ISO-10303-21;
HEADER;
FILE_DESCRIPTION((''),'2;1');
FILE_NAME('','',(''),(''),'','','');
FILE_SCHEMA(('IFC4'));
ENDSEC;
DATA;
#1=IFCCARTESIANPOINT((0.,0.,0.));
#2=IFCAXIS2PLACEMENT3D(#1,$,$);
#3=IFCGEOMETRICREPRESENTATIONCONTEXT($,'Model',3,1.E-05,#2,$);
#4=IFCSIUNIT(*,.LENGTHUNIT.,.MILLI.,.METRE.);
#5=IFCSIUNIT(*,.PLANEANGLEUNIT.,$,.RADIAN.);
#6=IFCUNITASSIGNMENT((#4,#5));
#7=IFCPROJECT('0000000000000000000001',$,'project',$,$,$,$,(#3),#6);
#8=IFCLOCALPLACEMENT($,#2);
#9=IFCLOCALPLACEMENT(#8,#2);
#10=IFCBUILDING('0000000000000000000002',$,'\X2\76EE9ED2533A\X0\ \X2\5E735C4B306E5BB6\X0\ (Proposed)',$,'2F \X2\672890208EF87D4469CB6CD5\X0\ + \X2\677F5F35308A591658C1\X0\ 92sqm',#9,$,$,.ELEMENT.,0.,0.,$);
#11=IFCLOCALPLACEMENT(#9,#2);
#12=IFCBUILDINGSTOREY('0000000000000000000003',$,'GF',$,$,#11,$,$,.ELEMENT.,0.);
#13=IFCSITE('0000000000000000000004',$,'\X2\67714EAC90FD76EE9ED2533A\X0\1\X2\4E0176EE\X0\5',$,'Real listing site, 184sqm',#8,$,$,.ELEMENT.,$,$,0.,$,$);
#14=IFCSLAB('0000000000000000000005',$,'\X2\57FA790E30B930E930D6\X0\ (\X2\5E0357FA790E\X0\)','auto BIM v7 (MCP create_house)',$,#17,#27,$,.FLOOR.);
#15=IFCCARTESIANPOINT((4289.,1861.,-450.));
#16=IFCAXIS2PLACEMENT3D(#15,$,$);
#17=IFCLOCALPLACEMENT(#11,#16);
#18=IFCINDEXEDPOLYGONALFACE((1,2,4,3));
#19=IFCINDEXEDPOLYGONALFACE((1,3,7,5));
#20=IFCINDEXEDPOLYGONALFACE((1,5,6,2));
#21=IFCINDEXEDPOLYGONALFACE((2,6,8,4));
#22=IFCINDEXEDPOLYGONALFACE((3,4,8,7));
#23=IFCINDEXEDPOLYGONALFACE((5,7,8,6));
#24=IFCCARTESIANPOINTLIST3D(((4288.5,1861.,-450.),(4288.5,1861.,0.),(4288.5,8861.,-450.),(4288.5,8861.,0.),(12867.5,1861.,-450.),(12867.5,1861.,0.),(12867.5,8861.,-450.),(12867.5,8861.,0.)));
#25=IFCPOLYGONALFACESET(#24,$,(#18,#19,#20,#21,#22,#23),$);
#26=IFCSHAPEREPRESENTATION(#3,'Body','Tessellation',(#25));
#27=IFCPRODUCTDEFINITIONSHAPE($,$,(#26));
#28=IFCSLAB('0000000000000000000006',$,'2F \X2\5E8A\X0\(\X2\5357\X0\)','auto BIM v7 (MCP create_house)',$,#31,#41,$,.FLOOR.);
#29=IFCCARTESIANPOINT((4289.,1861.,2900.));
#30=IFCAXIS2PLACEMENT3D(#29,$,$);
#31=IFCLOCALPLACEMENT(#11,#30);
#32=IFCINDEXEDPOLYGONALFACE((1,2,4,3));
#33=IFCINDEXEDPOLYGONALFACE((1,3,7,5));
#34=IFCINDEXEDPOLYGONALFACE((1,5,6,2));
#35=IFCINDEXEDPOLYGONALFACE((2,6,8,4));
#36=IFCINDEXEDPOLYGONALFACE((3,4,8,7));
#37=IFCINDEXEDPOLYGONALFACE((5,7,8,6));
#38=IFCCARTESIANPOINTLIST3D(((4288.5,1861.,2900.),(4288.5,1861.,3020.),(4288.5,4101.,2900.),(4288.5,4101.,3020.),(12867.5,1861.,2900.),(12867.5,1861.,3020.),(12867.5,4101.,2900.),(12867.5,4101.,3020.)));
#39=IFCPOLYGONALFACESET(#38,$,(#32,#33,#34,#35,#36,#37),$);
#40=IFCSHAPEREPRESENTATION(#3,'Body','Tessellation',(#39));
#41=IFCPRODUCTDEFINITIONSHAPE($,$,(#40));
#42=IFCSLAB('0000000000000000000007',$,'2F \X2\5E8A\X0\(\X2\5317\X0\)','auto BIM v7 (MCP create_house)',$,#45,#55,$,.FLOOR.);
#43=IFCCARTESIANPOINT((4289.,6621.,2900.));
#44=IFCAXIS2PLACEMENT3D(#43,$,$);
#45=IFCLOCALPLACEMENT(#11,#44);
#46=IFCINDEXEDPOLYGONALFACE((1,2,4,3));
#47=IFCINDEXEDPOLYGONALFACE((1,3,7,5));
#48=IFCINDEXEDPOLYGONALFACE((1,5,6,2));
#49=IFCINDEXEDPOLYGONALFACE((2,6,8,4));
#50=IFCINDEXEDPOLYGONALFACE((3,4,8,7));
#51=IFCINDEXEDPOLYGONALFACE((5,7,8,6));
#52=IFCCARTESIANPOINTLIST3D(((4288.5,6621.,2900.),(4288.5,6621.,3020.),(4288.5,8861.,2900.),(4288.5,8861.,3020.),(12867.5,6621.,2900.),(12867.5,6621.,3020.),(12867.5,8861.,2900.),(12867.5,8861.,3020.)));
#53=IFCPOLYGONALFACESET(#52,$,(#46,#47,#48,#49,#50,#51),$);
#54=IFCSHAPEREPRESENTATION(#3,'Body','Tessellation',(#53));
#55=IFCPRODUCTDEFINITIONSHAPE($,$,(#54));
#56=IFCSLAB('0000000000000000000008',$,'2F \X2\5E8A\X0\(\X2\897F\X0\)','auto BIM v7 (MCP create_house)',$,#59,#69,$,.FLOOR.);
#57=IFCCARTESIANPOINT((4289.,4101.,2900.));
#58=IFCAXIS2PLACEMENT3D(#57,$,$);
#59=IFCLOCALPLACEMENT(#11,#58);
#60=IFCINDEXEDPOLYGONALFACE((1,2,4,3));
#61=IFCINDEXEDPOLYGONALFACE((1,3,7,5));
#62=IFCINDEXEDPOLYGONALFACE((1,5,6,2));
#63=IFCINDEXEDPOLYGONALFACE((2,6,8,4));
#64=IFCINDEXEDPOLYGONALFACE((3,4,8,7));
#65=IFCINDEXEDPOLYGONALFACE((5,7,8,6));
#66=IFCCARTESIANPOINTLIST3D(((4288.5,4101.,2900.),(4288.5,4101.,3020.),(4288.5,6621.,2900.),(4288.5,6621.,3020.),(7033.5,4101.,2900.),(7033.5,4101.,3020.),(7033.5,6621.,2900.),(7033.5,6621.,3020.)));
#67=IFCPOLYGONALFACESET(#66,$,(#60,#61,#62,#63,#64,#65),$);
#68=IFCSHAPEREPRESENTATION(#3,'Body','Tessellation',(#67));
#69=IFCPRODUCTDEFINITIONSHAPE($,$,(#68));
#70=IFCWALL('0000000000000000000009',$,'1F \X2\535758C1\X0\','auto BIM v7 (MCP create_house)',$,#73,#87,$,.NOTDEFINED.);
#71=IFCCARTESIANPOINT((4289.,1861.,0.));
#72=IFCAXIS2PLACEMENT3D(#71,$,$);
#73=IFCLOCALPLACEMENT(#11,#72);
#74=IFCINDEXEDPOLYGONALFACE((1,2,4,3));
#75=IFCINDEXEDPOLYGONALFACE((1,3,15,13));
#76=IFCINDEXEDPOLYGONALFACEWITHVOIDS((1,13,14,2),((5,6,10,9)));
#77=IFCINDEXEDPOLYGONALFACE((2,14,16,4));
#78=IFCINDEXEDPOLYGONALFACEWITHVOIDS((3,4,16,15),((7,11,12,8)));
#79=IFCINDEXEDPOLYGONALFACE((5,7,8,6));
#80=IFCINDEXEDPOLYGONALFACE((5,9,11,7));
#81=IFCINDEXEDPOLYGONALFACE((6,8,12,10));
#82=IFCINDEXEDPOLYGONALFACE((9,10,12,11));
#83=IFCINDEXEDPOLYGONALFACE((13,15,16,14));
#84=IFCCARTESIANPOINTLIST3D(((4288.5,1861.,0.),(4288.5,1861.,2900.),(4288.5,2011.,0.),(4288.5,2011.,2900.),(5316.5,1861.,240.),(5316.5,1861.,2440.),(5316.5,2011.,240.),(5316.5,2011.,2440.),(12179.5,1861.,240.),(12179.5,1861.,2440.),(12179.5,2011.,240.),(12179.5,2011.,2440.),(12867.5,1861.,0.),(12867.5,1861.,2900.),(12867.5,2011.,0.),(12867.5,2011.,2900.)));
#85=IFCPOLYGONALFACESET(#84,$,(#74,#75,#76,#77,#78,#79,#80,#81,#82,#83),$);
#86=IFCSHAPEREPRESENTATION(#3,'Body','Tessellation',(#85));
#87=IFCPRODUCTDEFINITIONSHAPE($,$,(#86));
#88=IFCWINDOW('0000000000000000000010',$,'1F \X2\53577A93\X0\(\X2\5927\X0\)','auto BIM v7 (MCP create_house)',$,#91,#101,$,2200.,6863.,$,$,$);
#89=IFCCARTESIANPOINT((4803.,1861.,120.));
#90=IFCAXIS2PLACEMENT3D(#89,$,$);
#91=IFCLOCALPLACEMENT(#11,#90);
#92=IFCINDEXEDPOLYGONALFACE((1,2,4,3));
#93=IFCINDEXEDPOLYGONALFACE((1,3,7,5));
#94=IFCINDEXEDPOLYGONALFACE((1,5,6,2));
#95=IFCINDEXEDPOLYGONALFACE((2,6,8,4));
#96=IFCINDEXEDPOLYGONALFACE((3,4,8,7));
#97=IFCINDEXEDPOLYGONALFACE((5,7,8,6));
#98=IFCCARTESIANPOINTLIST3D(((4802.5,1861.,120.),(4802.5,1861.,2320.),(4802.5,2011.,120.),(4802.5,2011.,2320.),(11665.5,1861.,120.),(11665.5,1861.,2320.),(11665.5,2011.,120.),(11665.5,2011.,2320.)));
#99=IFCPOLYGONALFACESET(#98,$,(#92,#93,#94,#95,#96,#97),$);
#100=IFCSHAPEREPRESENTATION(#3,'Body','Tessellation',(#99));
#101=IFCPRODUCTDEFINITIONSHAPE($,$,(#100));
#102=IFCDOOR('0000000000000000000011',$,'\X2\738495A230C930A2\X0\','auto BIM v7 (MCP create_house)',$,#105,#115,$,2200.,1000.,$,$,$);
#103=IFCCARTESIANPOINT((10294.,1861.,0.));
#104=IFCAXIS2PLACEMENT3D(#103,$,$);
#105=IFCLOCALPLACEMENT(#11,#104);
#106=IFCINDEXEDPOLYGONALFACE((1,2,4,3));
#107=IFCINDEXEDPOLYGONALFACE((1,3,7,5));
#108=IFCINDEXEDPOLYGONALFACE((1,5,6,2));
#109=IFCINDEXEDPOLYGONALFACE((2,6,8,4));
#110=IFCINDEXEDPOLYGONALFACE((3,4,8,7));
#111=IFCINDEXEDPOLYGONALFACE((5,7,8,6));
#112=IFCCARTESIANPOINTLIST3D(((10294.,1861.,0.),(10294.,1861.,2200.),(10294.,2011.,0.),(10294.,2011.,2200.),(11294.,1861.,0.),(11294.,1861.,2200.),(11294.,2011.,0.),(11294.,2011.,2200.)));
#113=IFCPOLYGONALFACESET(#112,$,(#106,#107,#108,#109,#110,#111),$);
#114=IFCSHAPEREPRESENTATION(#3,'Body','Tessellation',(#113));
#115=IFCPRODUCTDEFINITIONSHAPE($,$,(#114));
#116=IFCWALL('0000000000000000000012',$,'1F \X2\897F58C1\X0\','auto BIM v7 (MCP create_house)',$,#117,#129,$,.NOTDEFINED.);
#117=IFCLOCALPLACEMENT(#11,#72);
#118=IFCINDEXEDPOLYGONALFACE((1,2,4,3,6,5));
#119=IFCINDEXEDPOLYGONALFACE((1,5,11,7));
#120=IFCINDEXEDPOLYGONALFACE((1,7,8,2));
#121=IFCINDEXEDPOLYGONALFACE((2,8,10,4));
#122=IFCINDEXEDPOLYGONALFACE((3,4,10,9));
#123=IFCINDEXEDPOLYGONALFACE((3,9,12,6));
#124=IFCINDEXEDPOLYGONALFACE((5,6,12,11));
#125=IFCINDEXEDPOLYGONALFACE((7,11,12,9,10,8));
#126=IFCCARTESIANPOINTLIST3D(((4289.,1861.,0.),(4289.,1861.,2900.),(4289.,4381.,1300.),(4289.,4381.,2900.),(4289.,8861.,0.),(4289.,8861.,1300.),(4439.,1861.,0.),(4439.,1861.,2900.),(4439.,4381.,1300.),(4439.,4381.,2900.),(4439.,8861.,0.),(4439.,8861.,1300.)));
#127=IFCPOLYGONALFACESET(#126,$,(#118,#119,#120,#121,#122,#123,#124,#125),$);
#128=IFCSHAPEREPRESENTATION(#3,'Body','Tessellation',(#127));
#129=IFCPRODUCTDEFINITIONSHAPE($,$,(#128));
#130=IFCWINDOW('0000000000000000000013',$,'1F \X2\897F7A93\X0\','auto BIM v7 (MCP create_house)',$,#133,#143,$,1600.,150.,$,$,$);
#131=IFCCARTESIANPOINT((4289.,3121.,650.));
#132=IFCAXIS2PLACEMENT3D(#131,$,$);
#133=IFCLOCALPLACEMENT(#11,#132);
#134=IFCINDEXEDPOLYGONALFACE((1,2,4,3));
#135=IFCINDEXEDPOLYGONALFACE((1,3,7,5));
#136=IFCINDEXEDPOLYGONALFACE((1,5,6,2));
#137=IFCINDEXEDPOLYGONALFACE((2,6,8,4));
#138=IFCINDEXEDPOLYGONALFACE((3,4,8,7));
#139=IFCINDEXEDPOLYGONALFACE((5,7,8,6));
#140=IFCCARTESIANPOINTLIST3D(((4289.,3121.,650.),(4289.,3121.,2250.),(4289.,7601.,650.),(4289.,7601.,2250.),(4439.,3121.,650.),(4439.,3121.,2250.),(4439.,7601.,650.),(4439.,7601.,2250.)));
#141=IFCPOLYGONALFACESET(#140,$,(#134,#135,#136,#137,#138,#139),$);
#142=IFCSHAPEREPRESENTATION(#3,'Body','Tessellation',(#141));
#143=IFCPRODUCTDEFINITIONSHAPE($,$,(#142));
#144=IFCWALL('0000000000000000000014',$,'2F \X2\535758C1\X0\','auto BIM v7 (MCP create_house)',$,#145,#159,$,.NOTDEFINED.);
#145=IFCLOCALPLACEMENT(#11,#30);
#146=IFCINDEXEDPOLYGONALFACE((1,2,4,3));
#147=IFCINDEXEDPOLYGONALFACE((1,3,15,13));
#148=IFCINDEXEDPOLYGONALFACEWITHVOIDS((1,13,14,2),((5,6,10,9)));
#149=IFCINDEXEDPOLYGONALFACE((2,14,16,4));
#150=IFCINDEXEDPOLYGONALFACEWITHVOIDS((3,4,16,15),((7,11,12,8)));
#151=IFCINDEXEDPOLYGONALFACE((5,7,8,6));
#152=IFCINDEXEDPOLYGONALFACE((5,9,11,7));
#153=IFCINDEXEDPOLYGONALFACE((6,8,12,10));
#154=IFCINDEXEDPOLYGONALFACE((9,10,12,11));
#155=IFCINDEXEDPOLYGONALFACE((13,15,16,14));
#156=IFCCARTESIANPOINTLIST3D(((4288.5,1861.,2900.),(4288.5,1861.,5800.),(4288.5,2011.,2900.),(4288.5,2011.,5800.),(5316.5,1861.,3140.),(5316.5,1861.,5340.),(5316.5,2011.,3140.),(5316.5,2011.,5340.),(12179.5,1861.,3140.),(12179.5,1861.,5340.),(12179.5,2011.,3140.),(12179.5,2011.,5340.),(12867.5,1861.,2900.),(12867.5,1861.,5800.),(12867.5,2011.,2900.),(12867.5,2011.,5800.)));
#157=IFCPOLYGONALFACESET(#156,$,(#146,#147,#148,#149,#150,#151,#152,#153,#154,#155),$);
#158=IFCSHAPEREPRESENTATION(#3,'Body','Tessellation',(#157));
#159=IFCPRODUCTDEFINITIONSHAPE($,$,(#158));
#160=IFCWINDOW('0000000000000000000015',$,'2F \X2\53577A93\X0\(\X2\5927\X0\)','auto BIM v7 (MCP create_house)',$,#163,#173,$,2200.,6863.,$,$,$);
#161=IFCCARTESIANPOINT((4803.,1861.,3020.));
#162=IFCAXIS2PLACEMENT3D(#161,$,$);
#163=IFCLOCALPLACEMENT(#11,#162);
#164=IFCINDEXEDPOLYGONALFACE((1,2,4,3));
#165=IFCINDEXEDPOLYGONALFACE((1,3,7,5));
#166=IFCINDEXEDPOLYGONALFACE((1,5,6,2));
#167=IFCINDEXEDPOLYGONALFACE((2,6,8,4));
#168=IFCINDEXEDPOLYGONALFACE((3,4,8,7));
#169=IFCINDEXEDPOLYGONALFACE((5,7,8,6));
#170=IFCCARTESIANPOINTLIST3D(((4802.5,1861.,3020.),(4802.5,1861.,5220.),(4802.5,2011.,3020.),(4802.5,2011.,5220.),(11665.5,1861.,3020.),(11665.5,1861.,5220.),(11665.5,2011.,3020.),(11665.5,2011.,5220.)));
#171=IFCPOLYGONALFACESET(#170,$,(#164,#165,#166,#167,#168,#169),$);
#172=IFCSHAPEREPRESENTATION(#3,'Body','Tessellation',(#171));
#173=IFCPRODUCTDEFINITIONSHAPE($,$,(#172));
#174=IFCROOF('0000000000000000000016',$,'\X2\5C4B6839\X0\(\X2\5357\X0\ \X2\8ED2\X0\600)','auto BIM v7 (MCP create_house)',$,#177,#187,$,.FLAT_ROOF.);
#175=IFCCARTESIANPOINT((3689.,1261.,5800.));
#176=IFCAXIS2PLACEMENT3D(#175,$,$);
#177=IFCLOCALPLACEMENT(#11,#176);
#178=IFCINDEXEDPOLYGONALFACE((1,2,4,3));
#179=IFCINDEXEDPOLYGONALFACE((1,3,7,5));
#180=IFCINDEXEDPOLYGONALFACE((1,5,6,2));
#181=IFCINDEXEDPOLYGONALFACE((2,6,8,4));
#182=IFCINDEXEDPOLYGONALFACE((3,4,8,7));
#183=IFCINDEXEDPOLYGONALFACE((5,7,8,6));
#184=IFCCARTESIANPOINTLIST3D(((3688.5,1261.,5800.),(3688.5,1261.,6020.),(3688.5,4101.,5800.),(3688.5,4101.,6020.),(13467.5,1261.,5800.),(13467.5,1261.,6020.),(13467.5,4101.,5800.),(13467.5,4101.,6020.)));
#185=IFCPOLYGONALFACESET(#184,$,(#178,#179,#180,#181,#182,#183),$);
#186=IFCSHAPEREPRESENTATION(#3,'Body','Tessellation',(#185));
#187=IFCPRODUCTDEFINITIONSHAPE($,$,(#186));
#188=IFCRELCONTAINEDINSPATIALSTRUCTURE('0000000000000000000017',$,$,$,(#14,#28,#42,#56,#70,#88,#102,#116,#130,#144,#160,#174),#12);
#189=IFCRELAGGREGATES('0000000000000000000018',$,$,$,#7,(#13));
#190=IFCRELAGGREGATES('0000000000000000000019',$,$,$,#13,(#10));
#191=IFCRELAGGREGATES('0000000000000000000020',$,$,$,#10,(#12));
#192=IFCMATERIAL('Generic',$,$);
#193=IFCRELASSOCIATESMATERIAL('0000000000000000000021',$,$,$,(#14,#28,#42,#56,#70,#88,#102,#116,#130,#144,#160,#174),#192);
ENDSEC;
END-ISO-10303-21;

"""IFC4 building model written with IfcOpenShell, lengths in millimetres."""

from ifc_helpers import new_model, si_unit, frame, frame_2d, origin, place, context, project, spatial, rectangle, extrude, material, element, fill, save


model = new_model("IFC4")

# Units and contexts
model_context = context("Model", 3, precision=1e-05, world=origin())
ifc_project = project(units=[si_unit("LENGTHUNIT", "METRE", prefix="MILLI"), si_unit("PLANEANGLEUNIT", "RADIAN")], contexts=[model_context])

# Site, building, storey
site_placement = place(None, origin())
site = spatial("IfcSite", under=ifc_project, at=site_placement, Name="東京都目黒区1丁目5", ObjectType="Real listing site, 184sqm", CompositionType="ELEMENT", RefElevation=0.0)
building_placement = place(site_placement, origin())
building = spatial("IfcBuilding", under=site, at=building_placement, Name="目黒区 平屋の家 (Proposed)", ObjectType="2F 木造軸組構法 + 板張り外壁 92sqm", CompositionType="ELEMENT", ElevationOfRefHeight=0.0, ElevationOfTerrain=0.0)
storey_placement = place(building_placement, origin())
storey = spatial("IfcBuildingStorey", under=building, at=storey_placement, Name="GF", CompositionType="ELEMENT", Elevation=0.0)

# Slabs
ifc_material = material(Name="Generic")
slab_1_placement = place(storey_placement, frame((4289.0, 1861.0, -450.0)))
element("IfcSlab", 1, at=slab_1_placement, inside=storey, material=ifc_material, Name="基礎スラブ (布基礎)", Description="auto BIM v7 (MCP create_house)", PredefinedType="FLOOR", context=model_context, shape_type="SweptSolid", body=[
    extrude(rectangle(XDim=8579.0, YDim=7000.0, at=frame_2d((4289.0, 3500.0))), frame((4289.0, 1861.0, -450.0)), (0.0, 0.0, 1.0), 450.0),
])
slab_2_placement = place(storey_placement, frame((4289.0, 1861.0, 2900.0)))
element("IfcSlab", 2, at=slab_2_placement, inside=storey, material=ifc_material, Name="2F 床(南)", Description="auto BIM v7 (MCP create_house)", PredefinedType="FLOOR", context=model_context, shape_type="SweptSolid", body=[
    extrude(rectangle(XDim=8579.0, YDim=2240.0, at=frame_2d((4289.0, 1120.0))), frame((4289.0, 1861.0, 2900.0)), (0.0, 0.0, 1.0), 120.0),
])
slab_3_placement = place(storey_placement, frame((4289.0, 6621.0, 2900.0)))
element("IfcSlab", 3, at=slab_3_placement, inside=storey, material=ifc_material, Name="2F 床(北)", Description="auto BIM v7 (MCP create_house)", PredefinedType="FLOOR", context=model_context, shape_type="SweptSolid", body=[
    extrude(rectangle(XDim=8579.0, YDim=2240.0, at=frame_2d((4289.0, 1120.0))), frame((4289.0, 6621.0, 2900.0)), (0.0, 0.0, 1.0), 120.0),
])
slab_4_placement = place(storey_placement, frame((4289.0, 4101.0, 2900.0)))
element("IfcSlab", 4, at=slab_4_placement, inside=storey, material=ifc_material, Name="2F 床(西)", Description="auto BIM v7 (MCP create_house)", PredefinedType="FLOOR", context=model_context, shape_type="SweptSolid", body=[
    extrude(rectangle(XDim=2745.0, YDim=2520.0, at=frame_2d((1372.0, 1260.0))), frame((4289.0, 4101.0, 2900.0)), (0.0, 0.0, 1.0), 120.0),
])

# Wall, openings, window, door
wall_1_placement = place(storey_placement, frame((4289.0, 1861.0, 0.0)))
wall_1 = element("IfcWall", 5, at=wall_1_placement, inside=storey, material=ifc_material, Name="1F 南壁", Description="auto BIM v7 (MCP create_house)", PredefinedType="NOTDEFINED", context=model_context, shape_type="SweptSolid", body=[
    extrude(rectangle(XDim=8579.0, YDim=150.0, at=frame_2d((4289.0, 75.0))), frame((4289.0, 1861.0, 0.0)), (0.0, 0.0, 1.0), 2900.0),
])
opening_1_placement = place(storey_placement, frame((4803.0, 1861.0, 120.0)))
opening_1 = element("IfcOpeningElement", 6, at=opening_1_placement, cuts=wall_1, PredefinedType="NOTDEFINED", context=model_context, shape_type="SweptSolid", body=[
    extrude(rectangle(XDim=6863.0, YDim=150.0, at=frame_2d((3431.0, 75.0))), frame((4803.0, 1861.0, 120.0)), (0.0, 0.0, 1.0), 2200.0),
])
opening_2_placement = place(storey_placement, frame((10294.0, 1861.0, 0.0)))
opening_2 = element("IfcOpeningElement", 7, at=opening_2_placement, cuts=wall_1, PredefinedType="NOTDEFINED", context=model_context, shape_type="SweptSolid", body=[
    extrude(rectangle(XDim=1000.0, YDim=150.0, at=frame_2d((500.0, 75.0))), frame((10294.0, 1861.0, 0.0)), (0.0, 0.0, 1.0), 2200.0),
])
window_1_placement = place(storey_placement, frame((4803.0, 1861.0, 120.0)))
window_1 = element("IfcWindow", 8, at=window_1_placement, inside=storey, material=ifc_material, Name="1F 南窓(大)", Description="auto BIM v7 (MCP create_house)", OverallHeight=2200.0, OverallWidth=6863.0, context=model_context, shape_type="SweptSolid", body=[
    extrude(rectangle(XDim=6863.0, YDim=150.0, at=frame_2d((3431.0, 75.0))), frame((4803.0, 1861.0, 120.0)), (0.0, 0.0, 1.0), 2200.0),
])
fill(opening_1, window_1)
door_placement = place(storey_placement, frame((10294.0, 1861.0, 0.0)))
door = element("IfcDoor", 9, at=door_placement, inside=storey, material=ifc_material, Name="玄関ドア", Description="auto BIM v7 (MCP create_house)", OverallHeight=2200.0, OverallWidth=1000.0, context=model_context, shape_type="SweptSolid", body=[
    extrude(rectangle(XDim=1000.0, YDim=150.0, at=frame_2d((500.0, 75.0))), frame((10294.0, 1861.0, 0.0)), (0.0, 0.0, 1.0), 2200.0),
])
fill(opening_2, door)

# Walls, openings, windows
wall_2_placement = place(storey_placement, frame((4289.0, 1861.0, 0.0)))
wall_2 = element("IfcWall", 10, at=wall_2_placement, inside=storey, material=ifc_material, Name="1F 西壁", Description="auto BIM v7 (MCP create_house)", PredefinedType="NOTDEFINED", context=model_context, shape_type="SweptSolid", body=[
    extrude(rectangle(XDim=150.0, YDim=7000.0, at=frame_2d((75.0, 3500.0))), frame((4289.0, 1861.0, 0.0)), (0.0, 0.0, 1.0), 2900.0),
])
opening_3_placement = place(storey_placement, frame((4289.0, 3121.0, 650.0)))
opening_3 = element("IfcOpeningElement", 11, at=opening_3_placement, cuts=wall_2, PredefinedType="NOTDEFINED", context=model_context, shape_type="SweptSolid", body=[
    extrude(rectangle(XDim=150.0, YDim=4480.0, at=frame_2d((75.0, 2240.0))), frame((4289.0, 3121.0, 650.0)), (0.0, 0.0, 1.0), 1600.0),
])
window_2_placement = place(storey_placement, frame((4289.0, 3121.0, 650.0)))
window_2 = element("IfcWindow", 12, at=window_2_placement, inside=storey, material=ifc_material, Name="1F 西窓", Description="auto BIM v7 (MCP create_house)", OverallHeight=1600.0, OverallWidth=150.0, context=model_context, shape_type="SweptSolid", body=[
    extrude(rectangle(XDim=150.0, YDim=4480.0, at=frame_2d((75.0, 2240.0))), frame((4289.0, 3121.0, 650.0)), (0.0, 0.0, 1.0), 1600.0),
])
fill(opening_3, window_2)
wall_3_placement = place(storey_placement, frame((4289.0, 1861.0, 2900.0)))
wall_3 = element("IfcWall", 13, at=wall_3_placement, inside=storey, material=ifc_material, Name="2F 南壁", Description="auto BIM v7 (MCP create_house)", PredefinedType="NOTDEFINED", context=model_context, shape_type="SweptSolid", body=[
    extrude(rectangle(XDim=8579.0, YDim=150.0, at=frame_2d((4289.0, 75.0))), frame((4289.0, 1861.0, 2900.0)), (0.0, 0.0, 1.0), 2900.0),
])
opening_4_placement = place(storey_placement, frame((4803.0, 1861.0, 3020.0)))
opening_4 = element("IfcOpeningElement", 14, at=opening_4_placement, cuts=wall_3, PredefinedType="NOTDEFINED", context=model_context, shape_type="SweptSolid", body=[
    extrude(rectangle(XDim=6863.0, YDim=150.0, at=frame_2d((3431.0, 75.0))), frame((4803.0, 1861.0, 3020.0)), (0.0, 0.0, 1.0), 2200.0),
])
window_3_placement = place(storey_placement, frame((4803.0, 1861.0, 3020.0)))
window_3 = element("IfcWindow", 15, at=window_3_placement, inside=storey, material=ifc_material, Name="2F 南窓(大)", Description="auto BIM v7 (MCP create_house)", OverallHeight=2200.0, OverallWidth=6863.0, context=model_context, shape_type="SweptSolid", body=[
    extrude(rectangle(XDim=6863.0, YDim=150.0, at=frame_2d((3431.0, 75.0))), frame((4803.0, 1861.0, 3020.0)), (0.0, 0.0, 1.0), 2200.0),
])
fill(opening_4, window_3)

# Roof
roof_1_placement = place(storey_placement, frame((3689.0, 1261.0, 5800.0)))
element("IfcRoof", 16, at=roof_1_placement, inside=storey, material=ifc_material, Name="屋根(南 軒600)", Description="auto BIM v7 (MCP create_house)", PredefinedType="FLAT_ROOF", context=model_context, shape_type="SweptSolid", body=[
    extrude(rectangle(XDim=9779.0, YDim=2840.0, at=frame_2d((4889.0, 1420.0))), frame((3689.0, 1261.0, 5800.0)), (0.0, 0.0, 1.0), 220.0),
])

save(model, "model.ifc")
